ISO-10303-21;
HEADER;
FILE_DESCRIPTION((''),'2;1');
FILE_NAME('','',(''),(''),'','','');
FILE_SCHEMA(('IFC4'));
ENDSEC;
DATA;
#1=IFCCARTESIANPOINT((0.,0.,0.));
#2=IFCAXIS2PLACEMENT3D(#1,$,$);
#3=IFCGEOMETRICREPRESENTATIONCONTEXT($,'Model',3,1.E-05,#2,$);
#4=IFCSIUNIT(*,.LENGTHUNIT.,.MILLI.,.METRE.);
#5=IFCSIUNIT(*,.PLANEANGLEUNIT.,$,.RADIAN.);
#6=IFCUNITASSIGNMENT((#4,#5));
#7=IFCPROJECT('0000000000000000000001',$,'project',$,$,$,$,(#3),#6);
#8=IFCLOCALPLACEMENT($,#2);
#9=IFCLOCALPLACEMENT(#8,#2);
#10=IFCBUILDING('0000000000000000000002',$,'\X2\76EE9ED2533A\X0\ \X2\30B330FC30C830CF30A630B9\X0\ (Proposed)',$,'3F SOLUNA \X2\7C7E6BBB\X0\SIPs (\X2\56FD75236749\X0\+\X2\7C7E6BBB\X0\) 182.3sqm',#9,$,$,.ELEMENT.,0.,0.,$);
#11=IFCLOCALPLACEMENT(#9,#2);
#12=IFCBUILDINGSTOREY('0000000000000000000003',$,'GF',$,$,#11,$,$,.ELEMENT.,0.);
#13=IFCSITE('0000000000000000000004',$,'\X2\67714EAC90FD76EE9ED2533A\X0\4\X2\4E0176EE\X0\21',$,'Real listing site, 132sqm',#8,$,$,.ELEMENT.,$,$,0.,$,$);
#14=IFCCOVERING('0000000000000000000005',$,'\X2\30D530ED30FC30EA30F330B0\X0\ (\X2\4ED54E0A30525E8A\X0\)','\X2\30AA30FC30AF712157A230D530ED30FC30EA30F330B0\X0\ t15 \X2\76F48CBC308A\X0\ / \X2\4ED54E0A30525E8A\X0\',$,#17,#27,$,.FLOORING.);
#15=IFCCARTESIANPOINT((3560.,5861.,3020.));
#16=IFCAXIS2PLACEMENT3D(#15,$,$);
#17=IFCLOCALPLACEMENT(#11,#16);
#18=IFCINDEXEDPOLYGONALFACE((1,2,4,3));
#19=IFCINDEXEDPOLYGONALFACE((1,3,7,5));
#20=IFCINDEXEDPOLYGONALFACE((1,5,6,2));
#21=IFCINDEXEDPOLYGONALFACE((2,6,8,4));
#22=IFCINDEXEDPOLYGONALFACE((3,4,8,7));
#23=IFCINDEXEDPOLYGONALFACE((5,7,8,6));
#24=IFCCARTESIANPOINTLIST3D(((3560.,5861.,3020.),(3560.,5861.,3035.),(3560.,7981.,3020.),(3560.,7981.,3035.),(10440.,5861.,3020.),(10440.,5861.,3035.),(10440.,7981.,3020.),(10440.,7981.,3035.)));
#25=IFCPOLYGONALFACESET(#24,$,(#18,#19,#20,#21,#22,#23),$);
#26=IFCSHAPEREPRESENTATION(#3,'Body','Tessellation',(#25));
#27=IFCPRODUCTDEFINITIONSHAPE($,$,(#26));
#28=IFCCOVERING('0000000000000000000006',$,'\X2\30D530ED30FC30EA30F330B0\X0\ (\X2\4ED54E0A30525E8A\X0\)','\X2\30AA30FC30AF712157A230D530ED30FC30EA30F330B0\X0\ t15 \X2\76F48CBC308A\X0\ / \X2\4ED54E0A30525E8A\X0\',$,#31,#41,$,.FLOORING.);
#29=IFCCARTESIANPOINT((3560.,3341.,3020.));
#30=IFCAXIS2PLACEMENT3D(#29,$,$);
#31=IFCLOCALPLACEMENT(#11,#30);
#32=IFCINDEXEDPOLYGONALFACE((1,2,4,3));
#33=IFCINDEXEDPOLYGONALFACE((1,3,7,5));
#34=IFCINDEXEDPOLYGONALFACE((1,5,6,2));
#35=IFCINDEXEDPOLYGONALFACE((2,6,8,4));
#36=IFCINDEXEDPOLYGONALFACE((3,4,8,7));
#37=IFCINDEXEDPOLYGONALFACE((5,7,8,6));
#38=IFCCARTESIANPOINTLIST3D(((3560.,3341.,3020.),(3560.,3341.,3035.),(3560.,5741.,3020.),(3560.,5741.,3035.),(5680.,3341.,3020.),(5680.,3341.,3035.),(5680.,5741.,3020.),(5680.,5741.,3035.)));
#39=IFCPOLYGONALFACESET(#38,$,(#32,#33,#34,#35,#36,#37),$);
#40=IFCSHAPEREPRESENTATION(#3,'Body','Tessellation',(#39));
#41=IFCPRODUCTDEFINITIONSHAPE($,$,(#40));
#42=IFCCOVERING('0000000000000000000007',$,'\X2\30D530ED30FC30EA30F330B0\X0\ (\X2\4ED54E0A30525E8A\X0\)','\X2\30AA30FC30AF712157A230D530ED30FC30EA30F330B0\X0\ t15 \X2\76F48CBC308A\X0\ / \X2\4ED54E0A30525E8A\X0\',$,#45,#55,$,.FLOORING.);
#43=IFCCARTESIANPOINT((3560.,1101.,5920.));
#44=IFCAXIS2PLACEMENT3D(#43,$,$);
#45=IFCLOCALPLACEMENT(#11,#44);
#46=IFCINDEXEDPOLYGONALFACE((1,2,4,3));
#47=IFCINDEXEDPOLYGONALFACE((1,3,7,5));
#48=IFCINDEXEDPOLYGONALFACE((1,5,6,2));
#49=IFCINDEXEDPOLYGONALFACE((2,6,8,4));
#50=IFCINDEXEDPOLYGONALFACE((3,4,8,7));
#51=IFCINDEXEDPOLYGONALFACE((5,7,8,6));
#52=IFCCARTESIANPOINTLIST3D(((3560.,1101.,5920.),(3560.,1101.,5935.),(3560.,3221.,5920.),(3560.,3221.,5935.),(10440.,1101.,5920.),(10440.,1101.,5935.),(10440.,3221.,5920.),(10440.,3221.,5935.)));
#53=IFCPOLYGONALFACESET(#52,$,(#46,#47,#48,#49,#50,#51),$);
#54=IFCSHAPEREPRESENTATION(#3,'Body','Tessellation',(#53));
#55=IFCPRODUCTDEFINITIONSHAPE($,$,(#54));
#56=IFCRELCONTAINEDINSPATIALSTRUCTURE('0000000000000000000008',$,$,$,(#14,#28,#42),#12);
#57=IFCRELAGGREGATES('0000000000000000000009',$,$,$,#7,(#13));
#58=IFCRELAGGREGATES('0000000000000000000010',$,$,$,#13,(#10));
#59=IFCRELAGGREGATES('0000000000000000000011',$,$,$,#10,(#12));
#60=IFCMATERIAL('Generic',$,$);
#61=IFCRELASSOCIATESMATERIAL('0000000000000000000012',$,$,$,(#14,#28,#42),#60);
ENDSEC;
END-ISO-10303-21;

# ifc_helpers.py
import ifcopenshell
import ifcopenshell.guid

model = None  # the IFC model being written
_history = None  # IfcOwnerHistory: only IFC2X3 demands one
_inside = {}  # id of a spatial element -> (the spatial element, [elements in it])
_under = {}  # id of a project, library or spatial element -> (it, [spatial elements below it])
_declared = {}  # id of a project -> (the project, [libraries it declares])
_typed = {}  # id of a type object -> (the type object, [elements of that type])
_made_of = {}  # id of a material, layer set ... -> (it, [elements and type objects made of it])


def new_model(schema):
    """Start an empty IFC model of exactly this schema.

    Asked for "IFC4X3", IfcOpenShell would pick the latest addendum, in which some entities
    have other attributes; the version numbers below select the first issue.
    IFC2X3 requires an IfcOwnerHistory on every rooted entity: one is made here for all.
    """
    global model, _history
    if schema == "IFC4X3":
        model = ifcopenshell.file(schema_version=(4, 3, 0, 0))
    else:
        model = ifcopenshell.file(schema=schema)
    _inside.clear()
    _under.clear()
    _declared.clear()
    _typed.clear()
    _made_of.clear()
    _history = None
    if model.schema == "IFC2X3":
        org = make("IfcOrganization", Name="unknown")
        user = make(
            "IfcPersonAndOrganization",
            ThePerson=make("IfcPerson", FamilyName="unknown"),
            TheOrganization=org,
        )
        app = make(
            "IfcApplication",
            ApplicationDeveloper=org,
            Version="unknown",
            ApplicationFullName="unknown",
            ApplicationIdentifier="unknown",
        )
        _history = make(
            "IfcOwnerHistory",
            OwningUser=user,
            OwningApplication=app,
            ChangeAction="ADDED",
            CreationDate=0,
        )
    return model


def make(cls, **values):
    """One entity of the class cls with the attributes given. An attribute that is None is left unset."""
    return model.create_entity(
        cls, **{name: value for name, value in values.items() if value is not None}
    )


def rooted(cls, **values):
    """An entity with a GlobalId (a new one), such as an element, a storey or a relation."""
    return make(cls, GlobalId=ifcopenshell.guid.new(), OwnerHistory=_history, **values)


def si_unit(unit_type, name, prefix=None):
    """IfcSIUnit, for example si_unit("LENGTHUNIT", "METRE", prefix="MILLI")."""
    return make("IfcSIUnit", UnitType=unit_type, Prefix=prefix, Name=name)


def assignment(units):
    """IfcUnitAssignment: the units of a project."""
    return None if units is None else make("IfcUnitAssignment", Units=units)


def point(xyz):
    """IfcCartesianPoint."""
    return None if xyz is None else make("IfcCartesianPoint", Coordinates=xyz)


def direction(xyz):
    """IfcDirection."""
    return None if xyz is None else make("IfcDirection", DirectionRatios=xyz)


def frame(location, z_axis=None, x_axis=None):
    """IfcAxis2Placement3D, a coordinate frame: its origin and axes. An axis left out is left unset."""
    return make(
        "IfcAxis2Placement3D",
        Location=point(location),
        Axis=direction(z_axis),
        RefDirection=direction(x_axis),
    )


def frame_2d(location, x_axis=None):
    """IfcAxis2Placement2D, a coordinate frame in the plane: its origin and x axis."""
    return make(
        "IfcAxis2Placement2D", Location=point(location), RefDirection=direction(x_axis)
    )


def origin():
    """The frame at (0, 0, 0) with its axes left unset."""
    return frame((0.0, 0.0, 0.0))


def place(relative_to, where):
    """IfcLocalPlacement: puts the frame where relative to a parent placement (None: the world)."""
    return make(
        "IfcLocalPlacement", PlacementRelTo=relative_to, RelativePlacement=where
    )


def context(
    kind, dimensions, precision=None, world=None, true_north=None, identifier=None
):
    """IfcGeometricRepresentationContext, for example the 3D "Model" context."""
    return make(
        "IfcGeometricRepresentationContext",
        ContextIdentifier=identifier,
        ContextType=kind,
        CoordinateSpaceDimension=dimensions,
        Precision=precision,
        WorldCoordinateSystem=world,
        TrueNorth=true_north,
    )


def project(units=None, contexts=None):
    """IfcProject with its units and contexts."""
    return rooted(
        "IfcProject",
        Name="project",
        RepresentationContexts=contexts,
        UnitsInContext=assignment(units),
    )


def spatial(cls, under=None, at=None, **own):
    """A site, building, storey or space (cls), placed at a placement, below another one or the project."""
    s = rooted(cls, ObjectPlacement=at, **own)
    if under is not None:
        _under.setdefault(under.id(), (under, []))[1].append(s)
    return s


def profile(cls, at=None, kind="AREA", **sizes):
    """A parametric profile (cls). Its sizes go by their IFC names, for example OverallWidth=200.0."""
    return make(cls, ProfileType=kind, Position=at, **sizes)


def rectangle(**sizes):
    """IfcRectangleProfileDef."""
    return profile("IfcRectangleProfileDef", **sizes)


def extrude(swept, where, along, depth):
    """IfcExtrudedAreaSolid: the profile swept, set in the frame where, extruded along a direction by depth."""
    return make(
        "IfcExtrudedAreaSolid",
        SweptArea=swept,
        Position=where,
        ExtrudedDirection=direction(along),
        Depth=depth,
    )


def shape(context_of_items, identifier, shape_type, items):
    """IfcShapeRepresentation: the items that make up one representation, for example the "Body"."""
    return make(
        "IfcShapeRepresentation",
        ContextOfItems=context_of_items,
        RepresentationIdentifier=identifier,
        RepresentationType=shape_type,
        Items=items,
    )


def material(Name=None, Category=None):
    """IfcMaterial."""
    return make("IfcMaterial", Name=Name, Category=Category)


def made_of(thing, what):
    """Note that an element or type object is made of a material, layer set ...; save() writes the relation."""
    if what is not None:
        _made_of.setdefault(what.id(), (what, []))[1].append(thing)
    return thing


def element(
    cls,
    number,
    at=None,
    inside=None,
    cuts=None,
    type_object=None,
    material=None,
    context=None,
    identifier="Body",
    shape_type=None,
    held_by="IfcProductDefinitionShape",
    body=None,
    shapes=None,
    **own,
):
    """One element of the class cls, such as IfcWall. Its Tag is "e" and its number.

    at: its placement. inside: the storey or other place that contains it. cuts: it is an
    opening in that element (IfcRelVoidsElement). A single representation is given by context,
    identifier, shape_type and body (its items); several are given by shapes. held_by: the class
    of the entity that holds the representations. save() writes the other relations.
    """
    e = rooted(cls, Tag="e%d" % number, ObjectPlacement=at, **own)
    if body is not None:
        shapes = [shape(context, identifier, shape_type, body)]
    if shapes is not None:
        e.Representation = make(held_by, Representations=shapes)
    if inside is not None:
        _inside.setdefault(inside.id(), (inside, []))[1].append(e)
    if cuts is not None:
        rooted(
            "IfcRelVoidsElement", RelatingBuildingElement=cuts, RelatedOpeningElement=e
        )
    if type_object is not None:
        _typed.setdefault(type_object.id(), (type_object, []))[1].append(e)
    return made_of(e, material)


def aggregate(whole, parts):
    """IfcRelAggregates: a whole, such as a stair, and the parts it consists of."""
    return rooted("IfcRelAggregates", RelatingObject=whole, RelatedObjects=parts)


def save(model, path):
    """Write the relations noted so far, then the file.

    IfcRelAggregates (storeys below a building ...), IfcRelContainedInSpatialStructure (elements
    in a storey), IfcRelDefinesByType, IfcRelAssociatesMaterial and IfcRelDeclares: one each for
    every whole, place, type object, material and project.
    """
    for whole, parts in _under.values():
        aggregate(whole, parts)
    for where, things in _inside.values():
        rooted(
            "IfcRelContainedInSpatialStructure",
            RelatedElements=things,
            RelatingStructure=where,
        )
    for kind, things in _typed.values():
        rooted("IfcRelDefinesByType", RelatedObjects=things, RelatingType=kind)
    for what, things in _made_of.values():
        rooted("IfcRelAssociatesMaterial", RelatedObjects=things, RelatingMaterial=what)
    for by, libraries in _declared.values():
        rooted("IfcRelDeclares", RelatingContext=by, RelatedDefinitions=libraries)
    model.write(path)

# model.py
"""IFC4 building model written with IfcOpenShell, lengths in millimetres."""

from ifc_helpers import new_model, si_unit, frame, frame_2d, origin, place, context, project, spatial, rectangle, extrude, material, element, save


model = new_model("IFC4")

# Units and contexts
model_context = context("Model", 3, precision=1e-05, world=origin())
ifc_project = project(units=[si_unit("LENGTHUNIT", "METRE", prefix="MILLI"), si_unit("PLANEANGLEUNIT", "RADIAN")], contexts=[model_context])

# Site, building, storey
site_placement = place(None, origin())
site = spatial("IfcSite", under=ifc_project, at=site_placement, Name="東京都目黒区4丁目21", ObjectType="Real listing site, 132sqm", CompositionType="ELEMENT", RefElevation=0.0)
building_placement = place(site_placement, origin())
building = spatial("IfcBuilding", under=site, at=building_placement, Name="目黒区 コートハウス (Proposed)", ObjectType="3F SOLUNA 籾殻SIPs (国産杉+籾殻) 182.3sqm", CompositionType="ELEMENT", ElevationOfRefHeight=0.0, ElevationOfTerrain=0.0)
storey_placement = place(building_placement, origin())
storey = spatial("IfcBuildingStorey", under=building, at=storey_placement, Name="GF", CompositionType="ELEMENT", Elevation=0.0)

# Shared definitions
ifc_material_1 = material(Name="Generic")

# Coverings
covering_1_placement = place(storey_placement, frame((3560.0, 5861.0, 3020.0)))
element("IfcCovering", 1, at=covering_1_placement, inside=storey, material=ifc_material_1, Name="フローリング (仕上げ床)", Description="オーク無垢フローリング t15 直貼り / 仕上げ床", PredefinedType="FLOORING", context=model_context, shape_type="SweptSolid", body=[
    extrude(rectangle(XDim=6880.0, YDim=2120.0, at=frame_2d((3440.0, 1060.0))), frame((3560.0, 5861.0, 3020.0)), (0.0, 0.0, 1.0), 15.0),
])
covering_2_placement = place(storey_placement, frame((3560.0, 3341.0, 3020.0)))
element("IfcCovering", 2, at=covering_2_placement, inside=storey, material=ifc_material_1, Name="フローリング (仕上げ床)", Description="オーク無垢フローリング t15 直貼り / 仕上げ床", PredefinedType="FLOORING", context=model_context, shape_type="SweptSolid", body=[
    extrude(rectangle(XDim=2120.0, YDim=2400.0, at=frame_2d((1060.0, 1200.0))), frame((3560.0, 3341.0, 3020.0)), (0.0, 0.0, 1.0), 15.0),
])
covering_3_placement = place(storey_placement, frame((3560.0, 1101.0, 5920.0)))
element("IfcCovering", 3, at=covering_3_placement, inside=storey, material=ifc_material_1, Name="フローリング (仕上げ床)", Description="オーク無垢フローリング t15 直貼り / 仕上げ床", PredefinedType="FLOORING", context=model_context, shape_type="SweptSolid", body=[
    extrude(rectangle(XDim=6880.0, YDim=2120.0, at=frame_2d((3440.0, 1060.0))), frame((3560.0, 1101.0, 5920.0)), (0.0, 0.0, 1.0), 15.0),
])

save(model, "model.ifc")
